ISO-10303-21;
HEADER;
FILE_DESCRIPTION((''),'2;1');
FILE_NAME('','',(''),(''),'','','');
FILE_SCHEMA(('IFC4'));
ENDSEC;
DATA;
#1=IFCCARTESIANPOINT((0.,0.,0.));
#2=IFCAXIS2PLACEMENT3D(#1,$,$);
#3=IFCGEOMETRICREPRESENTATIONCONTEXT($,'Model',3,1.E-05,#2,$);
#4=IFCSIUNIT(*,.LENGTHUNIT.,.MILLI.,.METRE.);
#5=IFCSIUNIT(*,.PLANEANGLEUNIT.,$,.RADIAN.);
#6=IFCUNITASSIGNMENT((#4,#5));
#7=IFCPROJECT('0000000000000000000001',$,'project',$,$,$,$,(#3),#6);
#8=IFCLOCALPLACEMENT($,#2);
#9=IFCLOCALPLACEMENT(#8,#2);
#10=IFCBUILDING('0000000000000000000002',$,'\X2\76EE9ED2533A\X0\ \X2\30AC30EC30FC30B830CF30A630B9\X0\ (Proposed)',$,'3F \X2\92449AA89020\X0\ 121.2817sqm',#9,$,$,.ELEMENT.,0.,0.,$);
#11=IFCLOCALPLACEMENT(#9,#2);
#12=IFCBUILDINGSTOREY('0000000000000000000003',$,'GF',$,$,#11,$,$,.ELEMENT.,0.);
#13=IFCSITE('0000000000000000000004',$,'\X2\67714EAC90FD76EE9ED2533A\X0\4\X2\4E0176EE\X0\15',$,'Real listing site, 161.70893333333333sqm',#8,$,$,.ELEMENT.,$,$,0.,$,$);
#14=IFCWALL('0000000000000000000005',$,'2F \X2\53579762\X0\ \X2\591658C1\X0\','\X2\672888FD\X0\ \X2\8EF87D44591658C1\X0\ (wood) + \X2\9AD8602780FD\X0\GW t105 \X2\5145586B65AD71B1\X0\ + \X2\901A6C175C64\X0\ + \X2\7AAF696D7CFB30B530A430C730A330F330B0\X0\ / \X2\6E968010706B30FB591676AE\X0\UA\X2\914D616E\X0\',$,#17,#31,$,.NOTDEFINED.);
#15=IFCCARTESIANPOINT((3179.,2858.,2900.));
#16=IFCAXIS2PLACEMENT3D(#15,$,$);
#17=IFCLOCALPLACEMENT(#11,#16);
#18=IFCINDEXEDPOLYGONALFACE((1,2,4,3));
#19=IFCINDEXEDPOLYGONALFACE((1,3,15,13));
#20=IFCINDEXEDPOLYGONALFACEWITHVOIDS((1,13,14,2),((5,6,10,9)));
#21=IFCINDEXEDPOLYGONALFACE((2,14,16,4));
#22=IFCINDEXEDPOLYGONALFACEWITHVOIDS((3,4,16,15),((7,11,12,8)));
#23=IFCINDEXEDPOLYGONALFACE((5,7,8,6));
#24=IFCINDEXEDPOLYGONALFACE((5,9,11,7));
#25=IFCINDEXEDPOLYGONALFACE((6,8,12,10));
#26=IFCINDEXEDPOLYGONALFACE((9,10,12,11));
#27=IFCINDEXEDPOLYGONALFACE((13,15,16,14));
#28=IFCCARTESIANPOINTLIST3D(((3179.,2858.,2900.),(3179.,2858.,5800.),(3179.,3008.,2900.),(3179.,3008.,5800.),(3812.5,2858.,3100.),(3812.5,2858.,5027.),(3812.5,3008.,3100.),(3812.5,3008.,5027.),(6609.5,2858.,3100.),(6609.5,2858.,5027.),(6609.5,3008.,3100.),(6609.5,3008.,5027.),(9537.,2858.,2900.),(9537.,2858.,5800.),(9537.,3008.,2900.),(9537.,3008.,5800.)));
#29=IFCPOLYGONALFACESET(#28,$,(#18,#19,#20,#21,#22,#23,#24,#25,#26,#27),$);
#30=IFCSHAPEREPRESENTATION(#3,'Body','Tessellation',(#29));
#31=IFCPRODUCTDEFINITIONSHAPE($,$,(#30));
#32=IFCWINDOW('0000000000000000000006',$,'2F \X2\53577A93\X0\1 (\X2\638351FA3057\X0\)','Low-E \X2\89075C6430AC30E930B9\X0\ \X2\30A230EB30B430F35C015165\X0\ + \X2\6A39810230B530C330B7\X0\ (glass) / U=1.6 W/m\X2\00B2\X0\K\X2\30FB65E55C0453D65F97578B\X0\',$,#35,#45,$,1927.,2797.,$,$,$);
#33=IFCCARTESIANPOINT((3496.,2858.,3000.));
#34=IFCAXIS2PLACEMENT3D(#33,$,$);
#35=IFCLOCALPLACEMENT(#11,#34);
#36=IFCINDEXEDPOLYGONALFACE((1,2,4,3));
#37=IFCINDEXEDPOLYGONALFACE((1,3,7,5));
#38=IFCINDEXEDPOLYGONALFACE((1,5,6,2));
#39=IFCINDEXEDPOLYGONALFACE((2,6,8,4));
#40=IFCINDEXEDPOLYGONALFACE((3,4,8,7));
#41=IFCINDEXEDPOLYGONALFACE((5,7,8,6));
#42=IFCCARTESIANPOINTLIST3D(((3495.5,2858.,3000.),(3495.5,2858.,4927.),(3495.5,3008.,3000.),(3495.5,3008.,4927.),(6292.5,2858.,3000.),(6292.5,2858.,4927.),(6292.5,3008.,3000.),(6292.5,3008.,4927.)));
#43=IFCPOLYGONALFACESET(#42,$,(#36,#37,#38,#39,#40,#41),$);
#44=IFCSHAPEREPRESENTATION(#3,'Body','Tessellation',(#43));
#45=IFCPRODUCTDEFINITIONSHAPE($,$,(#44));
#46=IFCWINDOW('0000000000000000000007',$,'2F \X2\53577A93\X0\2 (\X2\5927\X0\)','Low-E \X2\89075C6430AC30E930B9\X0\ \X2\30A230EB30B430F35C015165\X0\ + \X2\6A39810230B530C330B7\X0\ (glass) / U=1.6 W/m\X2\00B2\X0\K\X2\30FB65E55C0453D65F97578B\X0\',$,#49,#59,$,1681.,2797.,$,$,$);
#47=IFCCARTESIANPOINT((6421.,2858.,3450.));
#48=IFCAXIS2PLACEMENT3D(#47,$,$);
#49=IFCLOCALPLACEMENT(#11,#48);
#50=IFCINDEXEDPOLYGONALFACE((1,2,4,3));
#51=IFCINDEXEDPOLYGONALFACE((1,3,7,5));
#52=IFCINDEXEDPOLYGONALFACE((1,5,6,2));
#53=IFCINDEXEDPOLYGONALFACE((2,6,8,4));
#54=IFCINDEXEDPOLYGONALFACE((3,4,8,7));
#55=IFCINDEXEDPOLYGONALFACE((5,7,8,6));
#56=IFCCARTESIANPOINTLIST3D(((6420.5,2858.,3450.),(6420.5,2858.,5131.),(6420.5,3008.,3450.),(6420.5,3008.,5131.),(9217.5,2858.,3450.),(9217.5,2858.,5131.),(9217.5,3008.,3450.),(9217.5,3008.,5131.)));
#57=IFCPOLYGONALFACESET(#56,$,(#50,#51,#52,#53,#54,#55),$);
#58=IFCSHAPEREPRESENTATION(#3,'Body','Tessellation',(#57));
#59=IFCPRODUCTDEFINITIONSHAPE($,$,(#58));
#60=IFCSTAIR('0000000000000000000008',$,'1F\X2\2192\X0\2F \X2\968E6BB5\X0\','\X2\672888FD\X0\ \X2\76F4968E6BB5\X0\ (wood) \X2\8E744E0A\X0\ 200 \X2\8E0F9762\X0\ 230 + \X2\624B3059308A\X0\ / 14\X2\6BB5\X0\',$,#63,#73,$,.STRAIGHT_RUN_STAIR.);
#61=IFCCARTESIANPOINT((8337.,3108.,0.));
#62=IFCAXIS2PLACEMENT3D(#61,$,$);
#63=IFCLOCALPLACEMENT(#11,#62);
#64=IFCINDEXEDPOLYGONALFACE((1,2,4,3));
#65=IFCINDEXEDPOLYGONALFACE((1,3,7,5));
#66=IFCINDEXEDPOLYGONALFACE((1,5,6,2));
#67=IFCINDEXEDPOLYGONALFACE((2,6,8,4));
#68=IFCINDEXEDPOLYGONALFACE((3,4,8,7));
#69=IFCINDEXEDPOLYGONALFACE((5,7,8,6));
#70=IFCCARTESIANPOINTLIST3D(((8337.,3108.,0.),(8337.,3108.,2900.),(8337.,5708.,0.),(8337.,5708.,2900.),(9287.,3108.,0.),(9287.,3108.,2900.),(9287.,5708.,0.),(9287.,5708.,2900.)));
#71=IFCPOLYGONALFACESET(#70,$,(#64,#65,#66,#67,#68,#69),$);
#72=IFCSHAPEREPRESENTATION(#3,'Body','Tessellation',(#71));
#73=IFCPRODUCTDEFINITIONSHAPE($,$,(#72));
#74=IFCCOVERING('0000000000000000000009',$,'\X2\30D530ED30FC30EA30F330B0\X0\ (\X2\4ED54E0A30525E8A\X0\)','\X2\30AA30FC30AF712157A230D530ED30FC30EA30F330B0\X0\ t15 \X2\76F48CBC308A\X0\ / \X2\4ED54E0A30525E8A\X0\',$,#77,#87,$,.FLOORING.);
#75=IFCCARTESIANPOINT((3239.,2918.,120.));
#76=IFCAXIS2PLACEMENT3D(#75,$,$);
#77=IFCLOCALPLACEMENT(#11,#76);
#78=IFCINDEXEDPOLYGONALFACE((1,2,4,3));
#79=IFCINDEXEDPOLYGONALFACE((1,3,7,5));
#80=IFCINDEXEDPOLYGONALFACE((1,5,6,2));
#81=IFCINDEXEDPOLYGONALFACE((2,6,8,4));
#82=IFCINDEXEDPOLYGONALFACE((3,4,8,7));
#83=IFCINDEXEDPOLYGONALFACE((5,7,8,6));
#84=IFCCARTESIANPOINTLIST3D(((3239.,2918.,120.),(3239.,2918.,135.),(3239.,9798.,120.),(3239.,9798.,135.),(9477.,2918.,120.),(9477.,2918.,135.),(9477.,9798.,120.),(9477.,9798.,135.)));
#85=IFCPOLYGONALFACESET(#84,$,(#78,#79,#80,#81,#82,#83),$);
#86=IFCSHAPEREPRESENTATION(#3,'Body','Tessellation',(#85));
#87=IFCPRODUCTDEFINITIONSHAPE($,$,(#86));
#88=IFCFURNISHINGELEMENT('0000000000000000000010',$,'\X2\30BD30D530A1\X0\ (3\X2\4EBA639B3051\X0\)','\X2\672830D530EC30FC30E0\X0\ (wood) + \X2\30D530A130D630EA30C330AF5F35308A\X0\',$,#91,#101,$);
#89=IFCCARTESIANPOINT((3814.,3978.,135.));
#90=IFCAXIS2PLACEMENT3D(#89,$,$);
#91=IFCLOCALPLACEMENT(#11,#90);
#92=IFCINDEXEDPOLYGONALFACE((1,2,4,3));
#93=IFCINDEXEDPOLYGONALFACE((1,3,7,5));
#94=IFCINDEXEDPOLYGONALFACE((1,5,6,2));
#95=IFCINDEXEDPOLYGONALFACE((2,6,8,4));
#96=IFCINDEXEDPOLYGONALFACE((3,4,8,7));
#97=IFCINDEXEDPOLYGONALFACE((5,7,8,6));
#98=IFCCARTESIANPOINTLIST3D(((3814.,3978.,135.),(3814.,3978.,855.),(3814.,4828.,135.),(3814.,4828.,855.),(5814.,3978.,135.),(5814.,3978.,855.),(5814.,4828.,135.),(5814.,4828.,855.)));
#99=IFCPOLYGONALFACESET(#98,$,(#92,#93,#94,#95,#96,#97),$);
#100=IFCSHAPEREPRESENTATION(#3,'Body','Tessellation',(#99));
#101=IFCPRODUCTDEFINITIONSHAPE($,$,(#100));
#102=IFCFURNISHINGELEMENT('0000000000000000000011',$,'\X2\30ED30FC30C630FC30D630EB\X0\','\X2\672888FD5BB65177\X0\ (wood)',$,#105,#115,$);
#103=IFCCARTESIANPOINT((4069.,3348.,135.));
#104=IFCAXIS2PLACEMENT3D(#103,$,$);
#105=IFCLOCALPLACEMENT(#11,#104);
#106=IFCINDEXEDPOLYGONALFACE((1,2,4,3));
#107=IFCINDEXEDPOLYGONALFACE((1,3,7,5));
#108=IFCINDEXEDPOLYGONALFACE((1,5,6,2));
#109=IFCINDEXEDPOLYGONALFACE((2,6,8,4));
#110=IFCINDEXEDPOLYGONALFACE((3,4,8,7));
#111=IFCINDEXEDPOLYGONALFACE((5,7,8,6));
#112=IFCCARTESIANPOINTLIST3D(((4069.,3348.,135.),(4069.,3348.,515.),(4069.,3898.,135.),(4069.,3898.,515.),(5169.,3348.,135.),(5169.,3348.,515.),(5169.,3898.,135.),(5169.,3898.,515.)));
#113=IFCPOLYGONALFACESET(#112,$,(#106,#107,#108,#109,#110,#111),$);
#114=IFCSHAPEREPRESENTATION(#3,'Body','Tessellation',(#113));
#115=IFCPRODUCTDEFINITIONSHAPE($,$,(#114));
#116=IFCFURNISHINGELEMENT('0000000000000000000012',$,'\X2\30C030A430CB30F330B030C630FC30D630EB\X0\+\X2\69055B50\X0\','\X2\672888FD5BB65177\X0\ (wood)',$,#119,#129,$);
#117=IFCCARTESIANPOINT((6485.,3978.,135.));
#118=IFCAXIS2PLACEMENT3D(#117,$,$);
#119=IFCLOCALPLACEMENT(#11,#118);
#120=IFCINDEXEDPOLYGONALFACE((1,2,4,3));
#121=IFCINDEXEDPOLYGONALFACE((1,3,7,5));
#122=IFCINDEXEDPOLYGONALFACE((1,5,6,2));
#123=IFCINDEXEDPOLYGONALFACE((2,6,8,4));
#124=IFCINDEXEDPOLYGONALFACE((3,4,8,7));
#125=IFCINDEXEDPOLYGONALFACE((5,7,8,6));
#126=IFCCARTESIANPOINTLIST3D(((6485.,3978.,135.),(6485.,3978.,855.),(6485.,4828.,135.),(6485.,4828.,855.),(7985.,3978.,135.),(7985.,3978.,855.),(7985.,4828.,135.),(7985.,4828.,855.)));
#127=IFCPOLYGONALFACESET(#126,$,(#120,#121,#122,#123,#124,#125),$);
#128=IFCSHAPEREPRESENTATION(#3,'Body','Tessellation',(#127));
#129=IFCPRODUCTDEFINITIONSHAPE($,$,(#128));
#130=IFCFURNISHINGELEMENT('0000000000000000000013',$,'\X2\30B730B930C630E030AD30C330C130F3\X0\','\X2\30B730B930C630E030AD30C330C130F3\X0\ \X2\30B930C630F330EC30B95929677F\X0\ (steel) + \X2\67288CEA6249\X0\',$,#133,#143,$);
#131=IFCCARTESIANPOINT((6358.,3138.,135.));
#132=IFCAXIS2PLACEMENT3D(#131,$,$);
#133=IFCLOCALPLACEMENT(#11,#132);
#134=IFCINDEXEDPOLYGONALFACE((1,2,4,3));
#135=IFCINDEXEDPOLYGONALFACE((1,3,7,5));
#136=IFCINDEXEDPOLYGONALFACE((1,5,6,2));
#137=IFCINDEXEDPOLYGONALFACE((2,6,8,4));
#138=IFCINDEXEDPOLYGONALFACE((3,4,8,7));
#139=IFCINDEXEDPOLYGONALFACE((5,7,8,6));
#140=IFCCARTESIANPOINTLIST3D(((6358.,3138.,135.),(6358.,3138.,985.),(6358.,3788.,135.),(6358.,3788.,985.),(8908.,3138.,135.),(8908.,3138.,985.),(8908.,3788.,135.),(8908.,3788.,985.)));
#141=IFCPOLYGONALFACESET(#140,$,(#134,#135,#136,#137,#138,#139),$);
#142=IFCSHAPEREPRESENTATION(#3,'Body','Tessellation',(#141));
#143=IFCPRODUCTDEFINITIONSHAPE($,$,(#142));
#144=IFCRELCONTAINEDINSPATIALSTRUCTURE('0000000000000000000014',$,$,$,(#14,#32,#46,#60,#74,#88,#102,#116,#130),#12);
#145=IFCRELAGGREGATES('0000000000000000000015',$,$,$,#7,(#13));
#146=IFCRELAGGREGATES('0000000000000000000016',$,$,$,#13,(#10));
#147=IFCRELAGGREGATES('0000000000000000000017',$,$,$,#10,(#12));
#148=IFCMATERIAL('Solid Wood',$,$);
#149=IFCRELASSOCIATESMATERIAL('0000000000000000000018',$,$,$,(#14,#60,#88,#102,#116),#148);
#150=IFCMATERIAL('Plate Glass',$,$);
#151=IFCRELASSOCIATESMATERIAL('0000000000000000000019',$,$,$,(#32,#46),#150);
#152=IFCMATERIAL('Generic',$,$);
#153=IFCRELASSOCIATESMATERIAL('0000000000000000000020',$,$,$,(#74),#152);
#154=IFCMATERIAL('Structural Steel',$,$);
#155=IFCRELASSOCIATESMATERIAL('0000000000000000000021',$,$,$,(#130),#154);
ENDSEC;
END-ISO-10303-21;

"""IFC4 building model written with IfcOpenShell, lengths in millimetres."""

from ifc_helpers import new_model, si_unit, frame, frame_2d, origin, place, context, project, spatial, rectangle, extrude, material, element, fill, save


model = new_model("IFC4")

# Units and contexts
model_context = context("Model", 3, precision=1e-05, world=origin())
ifc_project = project(units=[si_unit("LENGTHUNIT", "METRE", prefix="MILLI"), si_unit("PLANEANGLEUNIT", "RADIAN")], contexts=[model_context])

# Site, building, storey
site_placement = place(None, origin())
site = spatial("IfcSite", under=ifc_project, at=site_placement, Name="東京都目黒区4丁目15", ObjectType="Real listing site, 161.70893333333333sqm", CompositionType="ELEMENT", RefElevation=0.0)
building_placement = place(site_placement, origin())
building = spatial("IfcBuilding", under=site, at=building_placement, Name="目黒区 ガレージハウス (Proposed)", ObjectType="3F 鉄骨造 121.2817sqm", CompositionType="ELEMENT", ElevationOfRefHeight=0.0, ElevationOfTerrain=0.0)
storey_placement = place(building_placement, origin())
storey = spatial("IfcBuildingStorey", under=building, at=storey_placement, Name="GF", CompositionType="ELEMENT", Elevation=0.0)

# Shared definitions
ifc_material_1 = material(Name="Solid Wood")

# Shared definitions
ifc_material_2 = material(Name="Plate Glass")

# Wall, openings, windows
wall_1_placement = place(storey_placement, frame((3179.0, 2858.0, 2900.0)))
wall_1 = element("IfcWall", 1, at=wall_1_placement, inside=storey, material=ifc_material_1, Name="2F 南面 外壁", Description="木製 軸組外壁 (wood) + 高性能GW t105 充填断熱 + 通気層 + 窯業系サイディング / 準耐火・外皮UA配慮", PredefinedType="NOTDEFINED", context=model_context, shape_type="SweptSolid", body=[
    extrude(rectangle(XDim=6358.0, YDim=150.0, at=frame_2d((3179.0, 75.0))), frame((3179.0, 2858.0, 2900.0)), (0.0, 0.0, 1.0), 2900.0),
])
opening_1_placement = place(storey_placement, frame((3496.0, 2858.0, 3000.0)))
opening_1 = element("IfcOpeningElement", 2, at=opening_1_placement, cuts=wall_1, PredefinedType="NOTDEFINED", context=model_context, shape_type="SweptSolid", body=[
    extrude(rectangle(XDim=2797.0, YDim=150.0, at=frame_2d((1398.0, 75.0))), frame((3496.0, 2858.0, 3000.0)), (0.0, 0.0, 1.0), 1927.0),
])
opening_2_placement = place(storey_placement, frame((6421.0, 2858.0, 3450.0)))
opening_2 = element("IfcOpeningElement", 3, at=opening_2_placement, cuts=wall_1, PredefinedType="NOTDEFINED", context=model_context, shape_type="SweptSolid", body=[
    extrude(rectangle(XDim=2797.0, YDim=150.0, at=frame_2d((1398.0, 75.0))), frame((6421.0, 2858.0, 3450.0)), (0.0, 0.0, 1.0), 1681.0),
])
window_1_placement = place(storey_placement, frame((3496.0, 2858.0, 3000.0)))
window_1 = element("IfcWindow", 4, at=window_1_placement, inside=storey, material=ifc_material_2, Name="2F 南窓1 (掃出し)", Description="Low-E 複層ガラス アルゴン封入 + 樹脂サッシ (glass) / U=1.6 W/m²K・日射取得型", OverallHeight=1927.0, OverallWidth=2797.0, context=model_context, shape_type="SweptSolid", body=[
    extrude(rectangle(XDim=2797.0, YDim=150.0, at=frame_2d((1398.0, 75.0))), frame((3496.0, 2858.0, 3000.0)), (0.0, 0.0, 1.0), 1927.0),
])
fill(opening_1, window_1)
window_2_placement = place(storey_placement, frame((6421.0, 2858.0, 3450.0)))
window_2 = element("IfcWindow", 5, at=window_2_placement, inside=storey, material=ifc_material_2, Name="2F 南窓2 (大)", Description="Low-E 複層ガラス アルゴン封入 + 樹脂サッシ (glass) / U=1.6 W/m²K・日射取得型", OverallHeight=1681.0, OverallWidth=2797.0, context=model_context, shape_type="SweptSolid", body=[
    extrude(rectangle(XDim=2797.0, YDim=150.0, at=frame_2d((1398.0, 75.0))), frame((6421.0, 2858.0, 3450.0)), (0.0, 0.0, 1.0), 1681.0),
])
fill(opening_2, window_2)

# Stair
stair_placement = place(storey_placement, frame((8337.0, 3108.0, 0.0)))
element("IfcStair", 6, at=stair_placement, inside=storey, material=ifc_material_1, Name="1F→2F 階段", Description="木製 直階段 (wood) 蹴上 200 踏面 230 + 手すり / 14段", PredefinedType="STRAIGHT_RUN_STAIR", context=model_context, shape_type="SweptSolid", body=[
    extrude(rectangle(XDim=950.0, YDim=2600.0, at=frame_2d((475.0, 1300.0))), frame((8337.0, 3108.0, 0.0)), (0.0, 0.0, 1.0), 2900.0),
])

# Covering
ifc_material_3 = material(Name="Generic")
covering_placement = place(storey_placement, frame((3239.0, 2918.0, 120.0)))
element("IfcCovering", 7, at=covering_placement, inside=storey, material=ifc_material_3, Name="フローリング (仕上げ床)", Description="オーク無垢フローリング t15 直貼り / 仕上げ床", PredefinedType="FLOORING", context=model_context, shape_type="SweptSolid", body=[
    extrude(rectangle(XDim=6238.0, YDim=6880.0, at=frame_2d((3119.0, 3440.0))), frame((3239.0, 2918.0, 120.0)), (0.0, 0.0, 1.0), 15.0),
])

# Furnishing elements
furnishing_1_placement = place(storey_placement, frame((3814.0, 3978.0, 135.0)))
element("IfcFurnishingElement", 8, at=furnishing_1_placement, inside=storey, material=ifc_material_1, Name="ソファ (3人掛け)", Description="木フレーム (wood) + ファブリック張り", context=model_context, shape_type="SweptSolid", body=[
    extrude(rectangle(XDim=2000.0, YDim=850.0, at=frame_2d((1000.0, 425.0))), frame((3814.0, 3978.0, 135.0)), (0.0, 0.0, 1.0), 720.0),
])
furnishing_2_placement = place(storey_placement, frame((4069.0, 3348.0, 135.0)))
element("IfcFurnishingElement", 9, at=furnishing_2_placement, inside=storey, material=ifc_material_1, Name="ローテーブル", Description="木製家具 (wood)", context=model_context, shape_type="SweptSolid", body=[
    extrude(rectangle(XDim=1100.0, YDim=550.0, at=frame_2d((550.0, 275.0))), frame((4069.0, 3348.0, 135.0)), (0.0, 0.0, 1.0), 380.0),
])
furnishing_3_placement = place(storey_placement, frame((6485.0, 3978.0, 135.0)))
element("IfcFurnishingElement", 10, at=furnishing_3_placement, inside=storey, material=ifc_material_1, Name="ダイニングテーブル+椅子", Description="木製家具 (wood)", context=model_context, shape_type="SweptSolid", body=[
    extrude(rectangle(XDim=1500.0, YDim=850.0, at=frame_2d((750.0, 425.0))), frame((6485.0, 3978.0, 135.0)), (0.0, 0.0, 1.0), 720.0),
])
ifc_material_4 = material(Name="Structural Steel")
furnishing_4_placement = place(storey_placement, frame((6358.0, 3138.0, 135.0)))
element("IfcFurnishingElement", 11, at=furnishing_4_placement, inside=storey, material=ifc_material_4, Name="システムキッチン", Description="システムキッチン ステンレス天板 (steel) + 木質扉", context=model_context, shape_type="SweptSolid", body=[
    extrude(rectangle(XDim=2550.0, YDim=650.0, at=frame_2d((1275.0, 325.0))), frame((6358.0, 3138.0, 135.0)), (0.0, 0.0, 1.0), 850.0),
])

save(model, "model.ifc")
